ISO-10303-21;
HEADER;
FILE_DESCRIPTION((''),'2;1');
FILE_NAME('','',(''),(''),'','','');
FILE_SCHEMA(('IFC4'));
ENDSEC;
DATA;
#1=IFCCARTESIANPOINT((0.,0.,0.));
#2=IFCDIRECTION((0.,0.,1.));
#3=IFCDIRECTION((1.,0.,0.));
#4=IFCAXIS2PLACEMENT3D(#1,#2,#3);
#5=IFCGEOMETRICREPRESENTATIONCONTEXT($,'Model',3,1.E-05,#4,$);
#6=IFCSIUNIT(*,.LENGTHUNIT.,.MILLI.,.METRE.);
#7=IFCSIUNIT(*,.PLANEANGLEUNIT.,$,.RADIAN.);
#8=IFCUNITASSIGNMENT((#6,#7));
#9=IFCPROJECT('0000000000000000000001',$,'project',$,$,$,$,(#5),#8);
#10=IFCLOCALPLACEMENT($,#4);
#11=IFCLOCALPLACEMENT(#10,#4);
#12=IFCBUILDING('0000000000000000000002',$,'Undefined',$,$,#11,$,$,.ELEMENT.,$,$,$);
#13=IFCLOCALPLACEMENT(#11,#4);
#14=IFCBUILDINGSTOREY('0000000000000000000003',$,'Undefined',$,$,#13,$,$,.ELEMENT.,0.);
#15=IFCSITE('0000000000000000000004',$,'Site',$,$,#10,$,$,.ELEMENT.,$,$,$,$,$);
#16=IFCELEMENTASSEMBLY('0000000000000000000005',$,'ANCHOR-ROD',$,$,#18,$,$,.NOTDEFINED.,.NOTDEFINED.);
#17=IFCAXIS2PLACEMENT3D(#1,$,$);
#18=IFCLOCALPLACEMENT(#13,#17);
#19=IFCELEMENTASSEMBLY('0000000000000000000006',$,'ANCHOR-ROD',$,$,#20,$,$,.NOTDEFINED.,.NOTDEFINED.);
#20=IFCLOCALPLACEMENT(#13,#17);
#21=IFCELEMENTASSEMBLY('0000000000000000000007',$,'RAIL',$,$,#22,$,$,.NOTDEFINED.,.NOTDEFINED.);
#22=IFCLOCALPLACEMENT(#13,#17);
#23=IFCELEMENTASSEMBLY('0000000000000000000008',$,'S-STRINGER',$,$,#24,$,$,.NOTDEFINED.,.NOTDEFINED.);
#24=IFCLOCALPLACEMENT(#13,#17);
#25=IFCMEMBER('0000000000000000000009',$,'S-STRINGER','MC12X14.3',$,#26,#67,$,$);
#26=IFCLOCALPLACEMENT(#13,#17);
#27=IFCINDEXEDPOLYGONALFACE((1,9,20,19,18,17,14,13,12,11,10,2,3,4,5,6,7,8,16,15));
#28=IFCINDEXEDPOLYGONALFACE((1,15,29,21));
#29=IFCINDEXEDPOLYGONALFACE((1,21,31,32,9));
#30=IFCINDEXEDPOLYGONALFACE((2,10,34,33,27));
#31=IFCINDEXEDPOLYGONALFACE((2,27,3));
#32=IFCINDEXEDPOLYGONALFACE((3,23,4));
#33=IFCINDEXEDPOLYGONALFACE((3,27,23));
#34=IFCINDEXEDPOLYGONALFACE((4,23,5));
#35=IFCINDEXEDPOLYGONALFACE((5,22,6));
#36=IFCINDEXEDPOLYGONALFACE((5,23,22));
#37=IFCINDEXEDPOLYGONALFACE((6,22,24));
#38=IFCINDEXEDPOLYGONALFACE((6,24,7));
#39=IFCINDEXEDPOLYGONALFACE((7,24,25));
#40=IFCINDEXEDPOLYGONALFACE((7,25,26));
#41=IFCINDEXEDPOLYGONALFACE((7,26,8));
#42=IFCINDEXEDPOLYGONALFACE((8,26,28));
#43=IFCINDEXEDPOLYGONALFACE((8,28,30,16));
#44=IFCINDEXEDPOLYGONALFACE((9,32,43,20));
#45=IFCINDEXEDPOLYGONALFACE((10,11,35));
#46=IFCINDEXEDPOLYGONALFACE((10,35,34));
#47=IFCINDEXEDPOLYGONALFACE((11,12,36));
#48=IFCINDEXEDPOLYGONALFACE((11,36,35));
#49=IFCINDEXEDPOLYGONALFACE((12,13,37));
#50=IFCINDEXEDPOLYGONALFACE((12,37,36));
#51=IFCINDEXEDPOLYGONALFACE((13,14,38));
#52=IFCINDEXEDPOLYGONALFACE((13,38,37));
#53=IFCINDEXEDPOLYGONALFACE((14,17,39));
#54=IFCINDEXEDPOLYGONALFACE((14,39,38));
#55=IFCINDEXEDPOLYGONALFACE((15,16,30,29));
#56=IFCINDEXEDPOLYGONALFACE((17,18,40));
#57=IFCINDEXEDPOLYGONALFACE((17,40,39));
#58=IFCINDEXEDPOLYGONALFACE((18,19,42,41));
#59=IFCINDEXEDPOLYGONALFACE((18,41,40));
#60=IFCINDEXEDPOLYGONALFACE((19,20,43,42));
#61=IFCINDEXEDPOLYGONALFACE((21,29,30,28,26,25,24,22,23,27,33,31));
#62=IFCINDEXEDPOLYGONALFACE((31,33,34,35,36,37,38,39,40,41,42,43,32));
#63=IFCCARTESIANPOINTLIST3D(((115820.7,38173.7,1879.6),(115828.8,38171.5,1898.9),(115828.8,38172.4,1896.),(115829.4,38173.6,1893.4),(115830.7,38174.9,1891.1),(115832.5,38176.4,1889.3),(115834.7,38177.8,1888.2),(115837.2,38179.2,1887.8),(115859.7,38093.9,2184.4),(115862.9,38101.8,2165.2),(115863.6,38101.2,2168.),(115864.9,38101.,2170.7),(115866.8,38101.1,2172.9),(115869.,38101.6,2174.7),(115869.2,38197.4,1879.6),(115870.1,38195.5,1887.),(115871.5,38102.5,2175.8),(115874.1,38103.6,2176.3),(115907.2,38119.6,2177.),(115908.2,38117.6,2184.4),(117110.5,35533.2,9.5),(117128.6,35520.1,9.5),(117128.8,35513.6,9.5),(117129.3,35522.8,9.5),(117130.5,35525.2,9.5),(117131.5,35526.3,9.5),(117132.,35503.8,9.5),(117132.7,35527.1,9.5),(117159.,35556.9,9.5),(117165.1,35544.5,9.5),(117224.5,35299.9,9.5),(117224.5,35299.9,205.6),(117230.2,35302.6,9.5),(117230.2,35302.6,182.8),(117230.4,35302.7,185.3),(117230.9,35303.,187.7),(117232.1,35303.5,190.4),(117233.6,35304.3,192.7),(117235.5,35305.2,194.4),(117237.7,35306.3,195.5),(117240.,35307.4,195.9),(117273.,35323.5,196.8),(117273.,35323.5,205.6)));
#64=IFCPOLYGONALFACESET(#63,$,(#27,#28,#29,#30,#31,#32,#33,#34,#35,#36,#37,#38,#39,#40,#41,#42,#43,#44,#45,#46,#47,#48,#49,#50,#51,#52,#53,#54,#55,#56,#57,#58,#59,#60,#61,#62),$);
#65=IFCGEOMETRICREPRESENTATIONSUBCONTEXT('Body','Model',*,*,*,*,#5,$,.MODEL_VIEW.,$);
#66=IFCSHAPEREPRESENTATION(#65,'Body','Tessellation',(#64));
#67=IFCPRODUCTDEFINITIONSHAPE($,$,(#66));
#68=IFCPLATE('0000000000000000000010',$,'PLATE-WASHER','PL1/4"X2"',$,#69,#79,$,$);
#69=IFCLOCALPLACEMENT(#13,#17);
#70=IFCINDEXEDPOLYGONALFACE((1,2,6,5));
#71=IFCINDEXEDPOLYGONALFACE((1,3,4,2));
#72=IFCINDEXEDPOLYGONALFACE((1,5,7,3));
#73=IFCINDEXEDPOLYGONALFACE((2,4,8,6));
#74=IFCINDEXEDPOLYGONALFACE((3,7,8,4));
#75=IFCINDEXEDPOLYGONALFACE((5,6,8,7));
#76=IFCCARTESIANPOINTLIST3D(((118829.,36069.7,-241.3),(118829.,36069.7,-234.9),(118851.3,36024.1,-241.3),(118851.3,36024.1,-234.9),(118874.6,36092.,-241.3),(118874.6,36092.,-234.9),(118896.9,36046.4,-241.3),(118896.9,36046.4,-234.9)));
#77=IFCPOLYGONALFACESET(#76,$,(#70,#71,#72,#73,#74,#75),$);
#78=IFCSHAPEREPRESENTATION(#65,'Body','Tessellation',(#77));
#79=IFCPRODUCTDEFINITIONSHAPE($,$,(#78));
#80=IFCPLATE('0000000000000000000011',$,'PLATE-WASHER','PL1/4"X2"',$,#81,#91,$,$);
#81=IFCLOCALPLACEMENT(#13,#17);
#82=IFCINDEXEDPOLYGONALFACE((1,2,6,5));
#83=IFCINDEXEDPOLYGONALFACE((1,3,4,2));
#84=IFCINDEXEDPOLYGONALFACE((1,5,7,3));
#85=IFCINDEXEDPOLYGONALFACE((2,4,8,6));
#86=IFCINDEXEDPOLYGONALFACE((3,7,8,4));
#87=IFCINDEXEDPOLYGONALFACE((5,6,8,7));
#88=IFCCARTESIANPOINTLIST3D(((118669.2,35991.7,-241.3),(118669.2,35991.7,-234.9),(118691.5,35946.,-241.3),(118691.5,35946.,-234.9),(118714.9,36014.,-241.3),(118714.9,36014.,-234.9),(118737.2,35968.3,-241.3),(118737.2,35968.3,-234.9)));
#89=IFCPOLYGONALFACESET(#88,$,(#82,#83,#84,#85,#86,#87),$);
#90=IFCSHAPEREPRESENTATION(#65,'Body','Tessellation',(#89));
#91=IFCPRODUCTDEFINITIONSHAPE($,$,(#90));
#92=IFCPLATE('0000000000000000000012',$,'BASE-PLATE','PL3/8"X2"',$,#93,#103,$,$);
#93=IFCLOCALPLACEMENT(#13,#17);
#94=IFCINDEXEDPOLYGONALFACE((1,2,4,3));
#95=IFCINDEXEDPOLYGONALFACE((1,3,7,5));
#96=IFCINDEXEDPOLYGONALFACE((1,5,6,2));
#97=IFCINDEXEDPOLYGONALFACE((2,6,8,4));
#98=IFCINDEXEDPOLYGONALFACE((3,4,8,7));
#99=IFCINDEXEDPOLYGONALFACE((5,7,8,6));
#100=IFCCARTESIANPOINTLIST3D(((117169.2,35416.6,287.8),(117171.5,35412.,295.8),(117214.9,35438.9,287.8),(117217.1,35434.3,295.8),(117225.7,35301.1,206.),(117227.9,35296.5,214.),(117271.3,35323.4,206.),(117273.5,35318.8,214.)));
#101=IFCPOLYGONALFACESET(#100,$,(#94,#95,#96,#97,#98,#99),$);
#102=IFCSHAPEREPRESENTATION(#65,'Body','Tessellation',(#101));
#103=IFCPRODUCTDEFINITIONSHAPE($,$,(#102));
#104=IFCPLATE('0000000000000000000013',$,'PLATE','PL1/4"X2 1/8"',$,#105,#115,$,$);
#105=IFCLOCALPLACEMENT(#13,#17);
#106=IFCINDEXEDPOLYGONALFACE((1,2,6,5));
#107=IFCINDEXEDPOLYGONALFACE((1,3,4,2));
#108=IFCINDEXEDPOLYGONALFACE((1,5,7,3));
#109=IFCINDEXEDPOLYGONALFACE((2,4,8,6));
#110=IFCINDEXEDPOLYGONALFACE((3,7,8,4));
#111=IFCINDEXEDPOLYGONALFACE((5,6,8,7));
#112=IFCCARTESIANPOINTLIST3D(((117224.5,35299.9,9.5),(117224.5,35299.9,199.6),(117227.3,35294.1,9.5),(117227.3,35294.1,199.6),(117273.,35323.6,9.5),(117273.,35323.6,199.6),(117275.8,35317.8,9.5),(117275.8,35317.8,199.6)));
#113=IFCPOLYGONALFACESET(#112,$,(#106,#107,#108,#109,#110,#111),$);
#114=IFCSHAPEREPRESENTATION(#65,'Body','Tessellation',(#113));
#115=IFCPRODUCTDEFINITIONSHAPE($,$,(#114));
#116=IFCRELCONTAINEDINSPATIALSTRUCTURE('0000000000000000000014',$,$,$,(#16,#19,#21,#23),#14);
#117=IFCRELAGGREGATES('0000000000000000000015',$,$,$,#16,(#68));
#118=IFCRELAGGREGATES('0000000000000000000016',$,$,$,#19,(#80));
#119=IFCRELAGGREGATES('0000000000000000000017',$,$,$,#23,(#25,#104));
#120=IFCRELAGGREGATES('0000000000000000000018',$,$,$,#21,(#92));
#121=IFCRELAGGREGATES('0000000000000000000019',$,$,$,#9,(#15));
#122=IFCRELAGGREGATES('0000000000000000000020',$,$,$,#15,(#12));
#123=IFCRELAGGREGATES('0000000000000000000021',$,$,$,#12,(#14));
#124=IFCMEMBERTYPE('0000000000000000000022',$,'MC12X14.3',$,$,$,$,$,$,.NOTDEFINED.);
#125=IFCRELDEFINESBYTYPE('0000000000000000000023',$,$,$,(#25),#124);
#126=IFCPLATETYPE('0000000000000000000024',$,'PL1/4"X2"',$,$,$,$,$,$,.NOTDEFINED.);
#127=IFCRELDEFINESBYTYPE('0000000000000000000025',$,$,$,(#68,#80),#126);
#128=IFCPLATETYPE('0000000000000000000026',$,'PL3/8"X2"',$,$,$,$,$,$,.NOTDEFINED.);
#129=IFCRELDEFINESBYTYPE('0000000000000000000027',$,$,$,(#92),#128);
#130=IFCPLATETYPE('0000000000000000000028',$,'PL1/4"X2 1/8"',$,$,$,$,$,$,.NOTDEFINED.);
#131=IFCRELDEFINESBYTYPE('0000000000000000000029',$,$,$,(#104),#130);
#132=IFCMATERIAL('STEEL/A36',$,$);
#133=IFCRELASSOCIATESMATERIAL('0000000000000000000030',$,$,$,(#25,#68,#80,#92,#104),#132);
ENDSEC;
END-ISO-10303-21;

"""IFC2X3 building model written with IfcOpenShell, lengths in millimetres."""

from ifc_helpers import new_model, si_unit, frame, origin_with_axes, origin_2d_with_axis, place, context, subcontext, project, spatial, polyline, u_section, outline, extrude, clip, halfspace, material, type_object, element, aggregate, save


model = new_model("IFC2X3")

# Units and contexts
model_context = context("Model", 3, precision=1e-05, world=origin_with_axes())
body_context = subcontext(model_context, "Body", "Model", "MODEL_VIEW")
ifc_project = project(units=[si_unit("LENGTHUNIT", "METRE", prefix="MILLI"), si_unit("PLANEANGLEUNIT", "RADIAN")], contexts=[model_context])

# Site, building, storey
site_placement = place(None, origin_with_axes())
site = spatial("IfcSite", under=ifc_project, at=site_placement, Name="Site", CompositionType="ELEMENT")
building_placement = place(site_placement, origin_with_axes())
building = spatial("IfcBuilding", under=site, at=building_placement, Name="Undefined", CompositionType="ELEMENT")
storey_placement = place(building_placement, origin_with_axes())
storey = spatial("IfcBuildingStorey", under=building, at=storey_placement, Name="Undefined", CompositionType="ELEMENT", Elevation=0.0)

# Element assemblies
assembly_1_placement = place(storey_placement, origin_with_axes())
assembly_1 = element("IfcElementAssembly", 1, at=assembly_1_placement, inside=storey, Name="ANCHOR-ROD", AssemblyPlace="NOTDEFINED", PredefinedType="NOTDEFINED")
assembly_2_placement = place(storey_placement, origin_with_axes())
assembly_2 = element("IfcElementAssembly", 2, at=assembly_2_placement, inside=storey, Name="ANCHOR-ROD", AssemblyPlace="NOTDEFINED", PredefinedType="NOTDEFINED")
assembly_3_placement = place(storey_placement, origin_with_axes())
assembly_3 = element("IfcElementAssembly", 3, at=assembly_3_placement, inside=storey, Name="RAIL", AssemblyPlace="NOTDEFINED", PredefinedType="NOTDEFINED")

# Element assembly
assembly_4_placement = place(storey_placement, origin_with_axes())
assembly_4 = element("IfcElementAssembly", 4, at=assembly_4_placement, inside=storey, Name="S-STRINGER", AssemblyPlace="NOTDEFINED", PredefinedType="NOTDEFINED")
ifc_material_1 = material(Name="STEEL/A36")

# Member
member_type_1 = type_object("IfcMemberType", Name="MC12X14.3", PredefinedType="NOTDEFINED")
member_1_placement = place(assembly_4_placement, frame((117252.4, 35304.3, 19.7), z_axis=(0.23564, -0.482399, 0.843661), x_axis=(-0.370291, 0.758056, 0.536875)))
member_1 = element("IfcMember", 5, at=member_1_placement, type_object=member_type_1, material=ifc_material_1, Name="S-STRINGER", Description="MC12X14.3", context=body_context, shape_type="Clipping", body=[
    clip(clip(clip(extrude(u_section(Depth=304.8, FlangeWidth=54.0, WebThickness=6.3, FlangeThickness=7.9, FilletRadius=11.1, FlangeSlope=0.019897, at=origin_2d_with_axis()), frame((3913.3, 0.0, 0.0), z_axis=(-1.0, 0.0, 0.0), x_axis=(0.0, -1.0, 0.0)), (0.0, 0.0, 1.0), 3913.3), halfspace(frame((223.0, 27.0, -154.0), z_axis=(-0.536875, 0.0, -0.843661), x_axis=(-0.843661, 0.0, 0.536875)), False)), halfspace(frame((-88.3, 27.0, -154.1), z_axis=(-0.843661, 0.0, 0.536875), x_axis=(0.536875, 0.0, 0.843661)), False)), halfspace(frame((3792.6, -27.0, 152.4), z_axis=(-0.960181, 0.0, 0.279378), x_axis=(0.0, -1.0, 0.0)), True)),
])

# Plates
plate_type_1 = type_object("IfcPlateType", Name="PL1/4\"X2\"", PredefinedType="NOTDEFINED")
plate_1_placement = place(assembly_1_placement, frame((118851.3, 36024.1, -238.1), z_axis=(0.0, 0.0, -1.0), x_axis=(-0.438909, 0.898531, 0.0)))
plate_1 = element("IfcPlate", 6, at=plate_1_placement, type_object=plate_type_1, material=ifc_material_1, Name="PLATE-WASHER", Description="PL1/4\"X2\"", context=body_context, shape_type="SweptSolid", body=[
    extrude(outline(polyline([(0.0, 0.0), (50.8, 0.0), (50.8, 50.8), (0.0, 50.8), (0.0, 0.0)])), frame((0.0, 0.0, -3.2), z_axis=(0.0, 0.0, 1.0), x_axis=(1.0, 0.0, 0.0)), (0.0, 0.0, 1.0), 6.4),
])
aggregate(assembly_1, [plate_1])
plate_2_placement = place(assembly_2_placement, frame((118691.5, 35946.0, -238.1), z_axis=(0.0, 0.0, -1.0), x_axis=(-0.438909, 0.898531, 0.0)))
plate_2 = element("IfcPlate", 7, at=plate_2_placement, type_object=plate_type_1, material=ifc_material_1, Name="PLATE-WASHER", Description="PL1/4\"X2\"", context=body_context, shape_type="SweptSolid", body=[
    extrude(outline(polyline([(0.0, 0.0), (50.8, 0.0), (50.8, 50.8), (0.0, 50.8), (0.0, 0.0)])), frame((0.0, 0.0, -3.2), z_axis=(0.0, 0.0, 1.0), x_axis=(1.0, 0.0, 0.0)), (0.0, 0.0, 1.0), 6.4),
])
aggregate(assembly_2, [plate_2])
plate_type_2 = type_object("IfcPlateType", Name="PL3/8\"X2\"", PredefinedType="NOTDEFINED")
plate_3_placement = place(assembly_3_placement, frame((117216.0, 35436.6, 291.8), z_axis=(0.23564, -0.482399, 0.843661), x_axis=(-0.898531, -0.43891, 0.0)))
plate_3 = element("IfcPlate", 8, at=plate_3_placement, type_object=plate_type_2, material=ifc_material_1, Name="BASE-PLATE", Description="PL3/8\"X2\"", context=body_context, shape_type="SweptSolid", body=[
    extrude(outline(polyline([(0.0, 0.0), (50.8, 0.0), (50.8, 152.4), (0.0, 152.4), (0.0, 0.0)])), frame((0.0, 0.0, -4.8), z_axis=(0.0, 0.0, 1.0), x_axis=(1.0, 0.0, 0.0)), (0.0, 0.0, 1.0), 9.5),
])
plate_type_3 = type_object("IfcPlateType", Name="PL1/4\"X2 1/8\"", PredefinedType="NOTDEFINED")
plate_4_placement = place(assembly_4_placement, frame((117250.1, 35308.8, 199.6), z_axis=(-0.438909, 0.898531, 0.0), x_axis=(0.0, 0.0, -1.0)))
plate_4 = element("IfcPlate", 9, at=plate_4_placement, type_object=plate_type_3, material=ifc_material_1, Name="PLATE", Description="PL1/4\"X2 1/8\"", context=body_context, shape_type="SweptSolid", body=[
    extrude(outline(polyline([(0.0, -27.0), (0.0, 27.0), (190.1, 27.0), (190.1, -27.0), (0.0, -27.0)])), frame((0.0, 0.0, -3.2), z_axis=(0.0, 0.0, 1.0), x_axis=(1.0, 0.0, 0.0)), (0.0, 0.0, 1.0), 6.4),
])
aggregate(assembly_4, [member_1, plate_4])

aggregate(assembly_3, [plate_3])

save(model, "model.ifc")
